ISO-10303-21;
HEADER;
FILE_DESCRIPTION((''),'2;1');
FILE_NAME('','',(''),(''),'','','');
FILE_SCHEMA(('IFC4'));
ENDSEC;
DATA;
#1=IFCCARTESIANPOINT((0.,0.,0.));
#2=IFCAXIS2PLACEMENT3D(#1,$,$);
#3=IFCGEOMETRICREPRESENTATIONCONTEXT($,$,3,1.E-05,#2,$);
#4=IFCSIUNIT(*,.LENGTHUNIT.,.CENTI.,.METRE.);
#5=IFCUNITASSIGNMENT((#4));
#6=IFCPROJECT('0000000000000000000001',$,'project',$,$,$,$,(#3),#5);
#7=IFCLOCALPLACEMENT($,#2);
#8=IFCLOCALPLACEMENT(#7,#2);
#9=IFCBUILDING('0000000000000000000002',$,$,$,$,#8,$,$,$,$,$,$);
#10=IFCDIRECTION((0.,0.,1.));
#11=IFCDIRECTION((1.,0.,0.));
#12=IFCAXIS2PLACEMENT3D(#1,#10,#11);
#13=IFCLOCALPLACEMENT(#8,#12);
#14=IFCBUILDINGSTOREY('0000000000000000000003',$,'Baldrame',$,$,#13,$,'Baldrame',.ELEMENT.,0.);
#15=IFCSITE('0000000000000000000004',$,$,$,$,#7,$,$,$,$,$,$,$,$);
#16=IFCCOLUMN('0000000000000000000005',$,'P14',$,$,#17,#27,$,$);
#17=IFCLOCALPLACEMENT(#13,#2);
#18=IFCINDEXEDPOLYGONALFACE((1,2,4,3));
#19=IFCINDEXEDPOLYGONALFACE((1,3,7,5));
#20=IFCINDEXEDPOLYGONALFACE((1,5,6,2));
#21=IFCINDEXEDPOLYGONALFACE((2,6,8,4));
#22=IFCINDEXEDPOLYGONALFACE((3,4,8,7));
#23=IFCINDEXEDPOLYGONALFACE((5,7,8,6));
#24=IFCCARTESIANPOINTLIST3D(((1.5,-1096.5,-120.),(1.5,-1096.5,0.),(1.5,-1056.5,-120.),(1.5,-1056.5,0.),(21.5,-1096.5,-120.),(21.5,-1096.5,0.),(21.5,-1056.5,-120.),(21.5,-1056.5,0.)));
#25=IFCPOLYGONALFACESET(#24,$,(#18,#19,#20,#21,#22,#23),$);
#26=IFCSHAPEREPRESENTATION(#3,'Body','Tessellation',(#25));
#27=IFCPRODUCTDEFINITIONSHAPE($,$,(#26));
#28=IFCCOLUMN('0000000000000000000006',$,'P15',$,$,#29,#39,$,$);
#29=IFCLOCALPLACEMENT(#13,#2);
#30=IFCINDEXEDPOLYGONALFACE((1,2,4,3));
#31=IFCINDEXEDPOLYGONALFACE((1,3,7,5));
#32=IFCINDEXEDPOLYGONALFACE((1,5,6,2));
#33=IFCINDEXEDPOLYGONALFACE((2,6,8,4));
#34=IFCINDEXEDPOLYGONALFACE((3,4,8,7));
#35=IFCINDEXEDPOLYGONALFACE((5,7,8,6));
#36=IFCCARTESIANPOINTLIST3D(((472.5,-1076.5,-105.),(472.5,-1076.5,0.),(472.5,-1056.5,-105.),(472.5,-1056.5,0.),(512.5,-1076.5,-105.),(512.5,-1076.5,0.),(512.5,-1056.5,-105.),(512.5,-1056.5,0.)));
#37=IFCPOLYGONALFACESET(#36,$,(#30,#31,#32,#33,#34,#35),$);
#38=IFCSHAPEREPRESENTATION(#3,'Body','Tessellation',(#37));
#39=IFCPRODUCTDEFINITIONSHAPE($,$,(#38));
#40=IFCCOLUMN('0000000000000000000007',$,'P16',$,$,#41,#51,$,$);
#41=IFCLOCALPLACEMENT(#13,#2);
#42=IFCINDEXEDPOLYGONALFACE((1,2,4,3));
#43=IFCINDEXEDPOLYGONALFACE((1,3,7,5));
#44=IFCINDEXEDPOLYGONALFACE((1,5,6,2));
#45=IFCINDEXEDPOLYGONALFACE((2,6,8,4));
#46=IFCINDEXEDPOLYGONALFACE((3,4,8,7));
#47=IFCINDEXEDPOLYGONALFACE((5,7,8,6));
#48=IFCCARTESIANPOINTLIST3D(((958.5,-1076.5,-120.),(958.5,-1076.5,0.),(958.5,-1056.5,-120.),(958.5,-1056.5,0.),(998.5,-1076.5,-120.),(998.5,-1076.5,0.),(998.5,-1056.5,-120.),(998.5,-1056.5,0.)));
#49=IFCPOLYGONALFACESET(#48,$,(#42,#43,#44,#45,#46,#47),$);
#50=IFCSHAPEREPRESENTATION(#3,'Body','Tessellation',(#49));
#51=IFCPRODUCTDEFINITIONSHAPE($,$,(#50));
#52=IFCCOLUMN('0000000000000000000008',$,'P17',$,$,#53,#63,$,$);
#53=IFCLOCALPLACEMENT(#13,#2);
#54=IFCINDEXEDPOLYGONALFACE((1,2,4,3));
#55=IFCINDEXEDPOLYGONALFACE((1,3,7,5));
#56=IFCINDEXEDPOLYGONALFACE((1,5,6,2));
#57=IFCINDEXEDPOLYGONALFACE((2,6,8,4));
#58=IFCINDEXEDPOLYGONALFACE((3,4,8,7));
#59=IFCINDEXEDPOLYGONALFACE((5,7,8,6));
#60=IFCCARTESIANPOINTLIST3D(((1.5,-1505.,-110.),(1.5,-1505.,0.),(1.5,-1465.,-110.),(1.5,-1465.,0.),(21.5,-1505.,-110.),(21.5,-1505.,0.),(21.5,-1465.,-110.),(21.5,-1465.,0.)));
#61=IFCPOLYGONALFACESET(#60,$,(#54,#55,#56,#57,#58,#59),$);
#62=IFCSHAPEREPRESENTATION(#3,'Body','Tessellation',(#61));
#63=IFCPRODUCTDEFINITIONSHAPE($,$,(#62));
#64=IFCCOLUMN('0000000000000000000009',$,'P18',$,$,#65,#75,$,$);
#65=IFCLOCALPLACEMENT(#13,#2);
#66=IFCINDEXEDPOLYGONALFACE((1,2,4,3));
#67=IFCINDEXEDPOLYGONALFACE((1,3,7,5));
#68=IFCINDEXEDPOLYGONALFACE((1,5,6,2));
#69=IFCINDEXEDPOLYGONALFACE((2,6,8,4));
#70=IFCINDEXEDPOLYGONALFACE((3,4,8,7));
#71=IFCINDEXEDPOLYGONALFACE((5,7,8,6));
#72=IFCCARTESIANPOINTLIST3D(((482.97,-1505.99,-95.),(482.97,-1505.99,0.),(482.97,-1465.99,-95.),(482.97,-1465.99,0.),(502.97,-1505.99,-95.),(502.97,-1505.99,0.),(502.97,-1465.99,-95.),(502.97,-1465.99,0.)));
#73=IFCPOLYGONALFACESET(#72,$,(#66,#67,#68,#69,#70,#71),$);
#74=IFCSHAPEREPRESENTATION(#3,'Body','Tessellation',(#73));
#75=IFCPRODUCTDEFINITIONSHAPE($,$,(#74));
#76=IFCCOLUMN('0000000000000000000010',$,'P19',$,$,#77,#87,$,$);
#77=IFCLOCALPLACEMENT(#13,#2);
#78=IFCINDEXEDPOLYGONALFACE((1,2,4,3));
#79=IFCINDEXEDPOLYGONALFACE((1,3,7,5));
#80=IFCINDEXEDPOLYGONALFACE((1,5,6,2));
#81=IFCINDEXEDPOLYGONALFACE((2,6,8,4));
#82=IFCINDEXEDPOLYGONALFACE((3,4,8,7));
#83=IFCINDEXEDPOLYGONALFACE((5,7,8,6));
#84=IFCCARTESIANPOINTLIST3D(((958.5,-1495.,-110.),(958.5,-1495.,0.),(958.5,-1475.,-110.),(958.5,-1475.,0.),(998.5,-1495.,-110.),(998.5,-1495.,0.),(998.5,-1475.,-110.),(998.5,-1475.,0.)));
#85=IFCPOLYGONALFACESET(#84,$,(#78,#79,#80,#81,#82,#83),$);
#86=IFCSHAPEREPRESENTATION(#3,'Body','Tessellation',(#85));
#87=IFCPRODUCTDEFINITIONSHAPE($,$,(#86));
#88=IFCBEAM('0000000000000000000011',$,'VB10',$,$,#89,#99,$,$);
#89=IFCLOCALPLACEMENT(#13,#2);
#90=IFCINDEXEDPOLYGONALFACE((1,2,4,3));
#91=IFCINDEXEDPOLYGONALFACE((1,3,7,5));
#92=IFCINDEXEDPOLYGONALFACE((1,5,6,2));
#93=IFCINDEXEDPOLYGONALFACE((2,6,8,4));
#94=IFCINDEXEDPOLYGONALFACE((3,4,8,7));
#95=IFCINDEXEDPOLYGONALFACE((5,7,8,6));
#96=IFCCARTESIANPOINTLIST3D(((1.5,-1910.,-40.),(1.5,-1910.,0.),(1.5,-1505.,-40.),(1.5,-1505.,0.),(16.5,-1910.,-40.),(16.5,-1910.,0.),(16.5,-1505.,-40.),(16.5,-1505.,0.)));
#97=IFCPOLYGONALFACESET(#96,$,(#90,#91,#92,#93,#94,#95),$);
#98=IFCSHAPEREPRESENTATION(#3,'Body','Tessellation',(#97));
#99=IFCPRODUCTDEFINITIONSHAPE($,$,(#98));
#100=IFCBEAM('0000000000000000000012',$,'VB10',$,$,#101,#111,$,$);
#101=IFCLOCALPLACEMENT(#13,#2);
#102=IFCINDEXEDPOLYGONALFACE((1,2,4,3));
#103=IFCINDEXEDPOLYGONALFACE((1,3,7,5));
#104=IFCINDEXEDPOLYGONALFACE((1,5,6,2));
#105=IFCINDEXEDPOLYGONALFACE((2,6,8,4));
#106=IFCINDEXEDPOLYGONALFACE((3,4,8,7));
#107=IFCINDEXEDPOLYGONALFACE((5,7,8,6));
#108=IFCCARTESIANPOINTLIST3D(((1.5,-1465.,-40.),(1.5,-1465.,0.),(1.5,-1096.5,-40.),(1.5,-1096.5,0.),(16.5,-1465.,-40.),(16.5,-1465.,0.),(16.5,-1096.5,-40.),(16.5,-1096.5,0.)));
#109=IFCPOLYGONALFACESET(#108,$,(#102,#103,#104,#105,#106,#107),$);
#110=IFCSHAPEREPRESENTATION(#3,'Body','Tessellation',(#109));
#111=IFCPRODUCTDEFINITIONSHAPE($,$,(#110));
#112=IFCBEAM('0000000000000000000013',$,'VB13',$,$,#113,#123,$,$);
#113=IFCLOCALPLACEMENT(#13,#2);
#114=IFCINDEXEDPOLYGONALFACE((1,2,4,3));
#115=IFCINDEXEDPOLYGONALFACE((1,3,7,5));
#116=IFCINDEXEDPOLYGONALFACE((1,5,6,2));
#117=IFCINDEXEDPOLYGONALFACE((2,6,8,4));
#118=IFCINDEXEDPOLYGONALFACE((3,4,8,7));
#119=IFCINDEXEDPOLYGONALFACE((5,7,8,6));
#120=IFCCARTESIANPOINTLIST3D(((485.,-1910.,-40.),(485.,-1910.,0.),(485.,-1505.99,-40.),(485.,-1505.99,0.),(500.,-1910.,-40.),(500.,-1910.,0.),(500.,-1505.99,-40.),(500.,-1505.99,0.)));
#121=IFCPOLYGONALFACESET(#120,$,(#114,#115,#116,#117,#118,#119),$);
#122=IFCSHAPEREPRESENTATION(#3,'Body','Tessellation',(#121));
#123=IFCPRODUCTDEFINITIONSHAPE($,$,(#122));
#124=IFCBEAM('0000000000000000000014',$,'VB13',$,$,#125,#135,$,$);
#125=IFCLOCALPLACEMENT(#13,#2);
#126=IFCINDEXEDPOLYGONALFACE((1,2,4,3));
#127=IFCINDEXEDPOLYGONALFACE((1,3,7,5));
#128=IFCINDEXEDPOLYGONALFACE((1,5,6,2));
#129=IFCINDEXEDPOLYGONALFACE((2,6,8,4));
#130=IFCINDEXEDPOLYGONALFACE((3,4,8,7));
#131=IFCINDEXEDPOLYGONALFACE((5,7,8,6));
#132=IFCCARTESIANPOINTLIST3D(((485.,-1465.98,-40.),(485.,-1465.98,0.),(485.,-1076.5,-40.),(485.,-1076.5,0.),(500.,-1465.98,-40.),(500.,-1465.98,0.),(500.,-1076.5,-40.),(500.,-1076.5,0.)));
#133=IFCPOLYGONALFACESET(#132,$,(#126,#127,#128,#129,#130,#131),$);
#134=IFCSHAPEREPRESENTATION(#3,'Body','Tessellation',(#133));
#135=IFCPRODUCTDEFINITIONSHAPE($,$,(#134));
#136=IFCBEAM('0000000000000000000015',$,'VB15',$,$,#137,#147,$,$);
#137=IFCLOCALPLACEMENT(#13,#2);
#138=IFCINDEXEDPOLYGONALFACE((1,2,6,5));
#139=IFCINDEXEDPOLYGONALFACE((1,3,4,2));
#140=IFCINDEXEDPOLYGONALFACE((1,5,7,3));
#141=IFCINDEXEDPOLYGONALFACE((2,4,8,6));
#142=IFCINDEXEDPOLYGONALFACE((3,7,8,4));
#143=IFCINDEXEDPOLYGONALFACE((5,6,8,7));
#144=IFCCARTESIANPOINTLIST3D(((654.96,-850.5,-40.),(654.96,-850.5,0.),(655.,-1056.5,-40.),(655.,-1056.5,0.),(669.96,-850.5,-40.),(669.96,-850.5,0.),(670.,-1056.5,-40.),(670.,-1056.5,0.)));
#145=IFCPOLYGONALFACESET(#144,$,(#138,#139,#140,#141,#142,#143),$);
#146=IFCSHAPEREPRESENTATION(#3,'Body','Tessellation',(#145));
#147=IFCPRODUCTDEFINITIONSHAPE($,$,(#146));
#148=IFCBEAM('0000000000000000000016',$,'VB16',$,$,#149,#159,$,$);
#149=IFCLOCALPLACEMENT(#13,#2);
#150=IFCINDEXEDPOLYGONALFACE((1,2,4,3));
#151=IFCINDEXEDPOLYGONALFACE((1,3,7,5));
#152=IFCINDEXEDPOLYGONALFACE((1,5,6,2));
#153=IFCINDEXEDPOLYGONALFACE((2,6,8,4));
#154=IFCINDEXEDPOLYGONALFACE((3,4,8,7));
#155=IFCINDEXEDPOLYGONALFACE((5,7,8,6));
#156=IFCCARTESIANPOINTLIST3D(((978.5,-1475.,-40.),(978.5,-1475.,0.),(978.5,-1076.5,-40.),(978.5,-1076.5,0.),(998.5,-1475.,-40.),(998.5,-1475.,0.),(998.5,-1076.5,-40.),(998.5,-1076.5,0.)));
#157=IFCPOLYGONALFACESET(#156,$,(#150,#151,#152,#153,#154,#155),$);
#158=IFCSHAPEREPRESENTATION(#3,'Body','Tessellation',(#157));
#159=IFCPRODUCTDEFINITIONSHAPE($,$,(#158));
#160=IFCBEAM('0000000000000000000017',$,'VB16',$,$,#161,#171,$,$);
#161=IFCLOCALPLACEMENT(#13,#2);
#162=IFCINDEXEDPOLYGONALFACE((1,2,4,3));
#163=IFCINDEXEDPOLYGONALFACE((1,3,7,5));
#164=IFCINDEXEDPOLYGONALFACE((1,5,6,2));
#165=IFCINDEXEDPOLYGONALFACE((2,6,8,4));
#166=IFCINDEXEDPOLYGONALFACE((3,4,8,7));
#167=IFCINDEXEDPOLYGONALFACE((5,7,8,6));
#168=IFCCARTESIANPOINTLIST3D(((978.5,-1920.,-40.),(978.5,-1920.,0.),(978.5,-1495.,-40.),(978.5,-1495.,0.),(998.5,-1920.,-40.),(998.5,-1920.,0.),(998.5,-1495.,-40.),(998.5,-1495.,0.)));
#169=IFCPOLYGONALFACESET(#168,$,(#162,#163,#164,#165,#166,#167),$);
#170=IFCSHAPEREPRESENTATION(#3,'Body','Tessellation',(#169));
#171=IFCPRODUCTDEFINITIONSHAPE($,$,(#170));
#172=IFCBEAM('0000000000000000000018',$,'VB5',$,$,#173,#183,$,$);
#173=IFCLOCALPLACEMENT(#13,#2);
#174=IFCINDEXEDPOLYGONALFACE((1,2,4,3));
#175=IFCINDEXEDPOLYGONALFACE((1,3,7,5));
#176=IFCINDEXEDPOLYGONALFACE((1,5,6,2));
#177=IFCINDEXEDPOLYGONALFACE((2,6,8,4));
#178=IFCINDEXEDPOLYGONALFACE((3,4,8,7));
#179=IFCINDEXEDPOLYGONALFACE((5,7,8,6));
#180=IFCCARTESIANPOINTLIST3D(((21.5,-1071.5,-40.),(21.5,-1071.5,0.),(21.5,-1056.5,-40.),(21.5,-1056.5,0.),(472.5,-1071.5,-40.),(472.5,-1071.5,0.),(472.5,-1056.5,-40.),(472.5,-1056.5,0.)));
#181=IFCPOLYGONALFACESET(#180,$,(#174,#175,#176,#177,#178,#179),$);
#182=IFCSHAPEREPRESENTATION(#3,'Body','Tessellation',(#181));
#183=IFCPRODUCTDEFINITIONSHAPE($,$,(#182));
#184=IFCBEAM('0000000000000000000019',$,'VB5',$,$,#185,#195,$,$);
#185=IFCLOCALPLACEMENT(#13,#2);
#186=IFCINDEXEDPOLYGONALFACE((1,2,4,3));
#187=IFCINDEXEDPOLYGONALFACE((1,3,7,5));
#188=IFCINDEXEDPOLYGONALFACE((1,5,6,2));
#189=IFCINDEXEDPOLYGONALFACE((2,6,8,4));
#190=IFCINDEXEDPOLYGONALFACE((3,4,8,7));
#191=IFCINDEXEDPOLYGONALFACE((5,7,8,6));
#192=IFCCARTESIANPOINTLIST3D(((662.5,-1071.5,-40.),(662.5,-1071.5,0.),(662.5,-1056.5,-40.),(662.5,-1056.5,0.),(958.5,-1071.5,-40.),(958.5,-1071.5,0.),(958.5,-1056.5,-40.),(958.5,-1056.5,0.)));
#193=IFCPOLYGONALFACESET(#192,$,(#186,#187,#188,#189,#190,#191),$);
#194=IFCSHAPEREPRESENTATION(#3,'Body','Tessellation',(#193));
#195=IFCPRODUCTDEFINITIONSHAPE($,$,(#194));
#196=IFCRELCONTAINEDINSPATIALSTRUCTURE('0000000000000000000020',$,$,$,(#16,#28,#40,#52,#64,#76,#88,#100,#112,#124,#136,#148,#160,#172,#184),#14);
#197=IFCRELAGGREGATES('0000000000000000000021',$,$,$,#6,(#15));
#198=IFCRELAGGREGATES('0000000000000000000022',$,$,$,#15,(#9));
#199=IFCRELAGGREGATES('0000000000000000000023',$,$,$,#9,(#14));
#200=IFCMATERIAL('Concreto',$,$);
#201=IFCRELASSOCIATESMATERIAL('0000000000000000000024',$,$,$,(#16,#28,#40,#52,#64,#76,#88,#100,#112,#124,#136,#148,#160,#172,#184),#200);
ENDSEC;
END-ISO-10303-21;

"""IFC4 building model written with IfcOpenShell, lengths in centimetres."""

from ifc_helpers import new_model, si_unit, frame, origin, origin_with_axes, place, context, project, spatial, polyline, outline, extrude, material, element, save


model = new_model("IFC4")

# Units and contexts
context_of_model = context(None, 3, precision=1e-05, world=origin())
ifc_project = project(units=[si_unit("LENGTHUNIT", "METRE", prefix="CENTI")], contexts=[context_of_model])

# Site, building, storey
site_placement = place(None, origin())
site = spatial("IfcSite", under=ifc_project, at=site_placement)
building_placement = place(site_placement, origin())
building = spatial("IfcBuilding", under=site, at=building_placement)
storey_placement = place(building_placement, origin_with_axes())
storey = spatial("IfcBuildingStorey", under=building, at=storey_placement, Name="Baldrame", LongName="Baldrame", CompositionType="ELEMENT", Elevation=0.0)

# Columns
ifc_material = material(Name="Concreto")
column_1_placement = place(storey_placement, frame((11.5, -1076.5, 0.0), z_axis=(0.0, 0.0, 1.0), x_axis=(1.0, 0.0, 0.0)))
element("IfcColumn", 1, at=column_1_placement, inside=storey, material=ifc_material, Name="P14", context=context_of_model, shape_type="SolidModel", body=[
    extrude(outline(polyline([(10.0, 20.0), (-10.0, 20.0), (-10.0, -20.0), (10.0, -20.0), (10.0, 20.0)])), frame((0.0, 0.0, -120.0), z_axis=(0.0, 0.0, 1.0), x_axis=(1.0, 0.0, 0.0)), (0.0, 0.0, 1.0), 120.0),
])
column_2_placement = place(storey_placement, frame((492.5, -1066.5, 0.0), z_axis=(0.0, 0.0, 1.0), x_axis=(1.0, 0.0, 0.0)))
element("IfcColumn", 2, at=column_2_placement, inside=storey, material=ifc_material, Name="P15", context=context_of_model, shape_type="SolidModel", body=[
    extrude(outline(polyline([(-20.0, 10.0), (-20.0, -10.0), (20.0, -10.0), (20.0, 10.0), (-20.0, 10.0)])), frame((0.0, 0.0, -105.0), z_axis=(0.0, 0.0, 1.0), x_axis=(1.0, 0.0, 0.0)), (0.0, 0.0, 1.0), 105.0),
])
column_3_placement = place(storey_placement, frame((978.5, -1066.5, 0.0), z_axis=(0.0, 0.0, 1.0), x_axis=(1.0, 0.0, 0.0)))
element("IfcColumn", 3, at=column_3_placement, inside=storey, material=ifc_material, Name="P16", context=context_of_model, shape_type="SolidModel", body=[
    extrude(outline(polyline([(-20.0, 10.0), (-20.0, -10.0), (20.0, -10.0), (20.0, 10.0), (-20.0, 10.0)])), frame((0.0, 0.0, -120.0), z_axis=(0.0, 0.0, 1.0), x_axis=(1.0, 0.0, 0.0)), (0.0, 0.0, 1.0), 120.0),
])
column_4_placement = place(storey_placement, frame((11.5, -1485.0, 0.0), z_axis=(0.0, 0.0, 1.0), x_axis=(1.0, 0.0, 0.0)))
element("IfcColumn", 4, at=column_4_placement, inside=storey, material=ifc_material, Name="P17", context=context_of_model, shape_type="SolidModel", body=[
    extrude(outline(polyline([(-10.0, -20.0), (10.0, -20.0), (10.0, 20.0), (-10.0, 20.0), (-10.0, -20.0)])), frame((0.0, 0.0, -110.0), z_axis=(0.0, 0.0, 1.0), x_axis=(1.0, 0.0, 0.0)), (0.0, 0.0, 1.0), 110.0),
])
column_5_placement = place(storey_placement, frame((492.97, -1485.99, 0.0), z_axis=(0.0, 0.0, 1.0), x_axis=(1.0, 0.0, 0.0)))
element("IfcColumn", 5, at=column_5_placement, inside=storey, material=ifc_material, Name="P18", context=context_of_model, shape_type="SolidModel", body=[
    extrude(outline(polyline([(-10.0, -20.0), (10.0, -20.0), (10.0, 20.0), (-10.0, 20.0), (-10.0, -20.0)])), frame((0.0, 0.0, -95.0), z_axis=(0.0, 0.0, 1.0), x_axis=(1.0, 0.0, 0.0)), (0.0, 0.0, 1.0), 95.0),
])
column_6_placement = place(storey_placement, frame((978.5, -1485.0, 0.0), z_axis=(0.0, 0.0, 1.0), x_axis=(1.0, 0.0, 0.0)))
element("IfcColumn", 6, at=column_6_placement, inside=storey, material=ifc_material, Name="P19", context=context_of_model, shape_type="SolidModel", body=[
    extrude(outline(polyline([(-20.0, 10.0), (-20.0, -10.0), (20.0, -10.0), (20.0, 10.0), (-20.0, 10.0)])), frame((0.0, 0.0, -110.0), z_axis=(0.0, 0.0, 1.0), x_axis=(1.0, 0.0, 0.0)), (0.0, 0.0, 1.0), 110.0),
])

# Beams
beam_1_placement = place(storey_placement, frame((9.0, -1707.5, 0.0), z_axis=(0.0, 0.0, 1.0), x_axis=(1.0, 0.0, 0.0)))
element("IfcBeam", 7, at=beam_1_placement, inside=storey, material=ifc_material, Name="VB10", context=context_of_model, shape_type="SolidModel", body=[
    extrude(outline(polyline([(-7.5, -20.0), (7.5, -20.0), (7.5, 20.0), (-7.5, 20.0), (-7.5, -20.0)])), frame((0.0, -202.5, -20.0), z_axis=(0.0, 1.0, 0.0), x_axis=(1.0, 0.0, 0.0)), (0.0, 0.0, 1.0), 405.0),
])
beam_2_placement = place(storey_placement, frame((9.0, -1280.75, 0.0), z_axis=(0.0, 0.0, 1.0), x_axis=(1.0, 0.0, 0.0)))
element("IfcBeam", 8, at=beam_2_placement, inside=storey, material=ifc_material, Name="VB10", context=context_of_model, shape_type="SolidModel", body=[
    extrude(outline(polyline([(-7.5, -20.0), (7.5, -20.0), (7.5, 20.0), (-7.5, 20.0), (-7.5, -20.0)])), frame((0.0, -184.25, -20.0), z_axis=(0.0, 1.0, 0.0), x_axis=(1.0, 0.0, 0.0)), (0.0, 0.0, 1.0), 368.5),
])
beam_3_placement = place(storey_placement, frame((492.5, -1707.99, 0.0), z_axis=(0.0, 0.0, 1.0), x_axis=(1.0, 0.0, 0.0)))
element("IfcBeam", 9, at=beam_3_placement, inside=storey, material=ifc_material, Name="VB13", context=context_of_model, shape_type="SolidModel", body=[
    extrude(outline(polyline([(-7.5, -20.0), (7.5, -20.0), (7.5, 20.0), (-7.5, 20.0), (-7.5, -20.0)])), frame((0.0, -202.0, -20.0), z_axis=(0.0, 1.0, 0.0), x_axis=(1.0, 0.0, 0.0)), (0.0, 0.0, 1.0), 404.01),
])
beam_4_placement = place(storey_placement, frame((492.5, -1271.24, 0.0), z_axis=(0.0, 0.0, 1.0), x_axis=(1.0, 0.0, 0.0)))
element("IfcBeam", 10, at=beam_4_placement, inside=storey, material=ifc_material, Name="VB13", context=context_of_model, shape_type="SolidModel", body=[
    extrude(outline(polyline([(-7.5, -20.0), (7.5, -20.0), (7.5, 20.0), (-7.5, 20.0), (-7.5, -20.0)])), frame((0.0, -194.75, -20.0), z_axis=(0.0, 1.0, 0.0), x_axis=(1.0, 0.0, 0.0)), (0.0, 0.0, 1.0), 389.49),
])
beam_5_placement = place(storey_placement, frame((662.48, -953.5, 0.0), z_axis=(0.0, 0.0, 1.0), x_axis=(1.0, 0.0, 0.0)))
element("IfcBeam", 11, at=beam_5_placement, inside=storey, material=ifc_material, Name="VB15", context=context_of_model, shape_type="SolidModel", body=[
    extrude(outline(polyline([(-7.5, -20.0), (7.5, -20.0), (7.5, 20.0), (-7.5, 20.0), (-7.5, -20.0)])), frame((0.02, -103.0, -20.0), z_axis=(-0.000187, 1.0, 0.0), x_axis=(1.0, 0.000187, 0.0)), (0.0, 0.0, 1.0), 206.0),
])
beam_6_placement = place(storey_placement, frame((988.5, -1275.75, 0.0), z_axis=(0.0, 0.0, 1.0), x_axis=(1.0, 0.0, 0.0)))
element("IfcBeam", 12, at=beam_6_placement, inside=storey, material=ifc_material, Name="VB16", context=context_of_model, shape_type="SolidModel", body=[
    extrude(outline(polyline([(-10.0, -20.0), (10.0, -20.0), (10.0, 20.0), (-10.0, 20.0), (-10.0, -20.0)])), frame((0.0, -199.25, -20.0), z_axis=(0.0, 1.0, 0.0), x_axis=(1.0, 0.0, 0.0)), (0.0, 0.0, 1.0), 398.5),
])
beam_7_placement = place(storey_placement, frame((988.5, -1707.5, 0.0), z_axis=(0.0, 0.0, 1.0), x_axis=(1.0, 0.0, 0.0)))
element("IfcBeam", 13, at=beam_7_placement, inside=storey, material=ifc_material, Name="VB16", context=context_of_model, shape_type="SolidModel", body=[
    extrude(outline(polyline([(-10.0, -20.0), (10.0, -20.0), (10.0, 20.0), (-10.0, 20.0), (-10.0, -20.0)])), frame((0.0, -212.5, -20.0), z_axis=(0.0, 1.0, 0.0), x_axis=(1.0, 0.0, 0.0)), (0.0, 0.0, 1.0), 425.0),
])
beam_8_placement = place(storey_placement, frame((247.0, -1064.0, 0.0), z_axis=(0.0, 0.0, 1.0), x_axis=(1.0, 0.0, 0.0)))
element("IfcBeam", 14, at=beam_8_placement, inside=storey, material=ifc_material, Name="VB5", context=context_of_model, shape_type="SolidModel", body=[
    extrude(outline(polyline([(-7.5, -20.0), (7.5, -20.0), (7.5, 20.0), (-7.5, 20.0), (-7.5, -20.0)])), frame((-225.5, 0.0, -20.0), z_axis=(1.0, 0.0, 0.0), x_axis=(0.0, -1.0, 0.0)), (0.0, 0.0, 1.0), 451.0),
])
beam_9_placement = place(storey_placement, frame((810.5, -1064.0, 0.0), z_axis=(0.0, 0.0, 1.0), x_axis=(1.0, 0.0, 0.0)))
element("IfcBeam", 15, at=beam_9_placement, inside=storey, material=ifc_material, Name="VB5", context=context_of_model, shape_type="SolidModel", body=[
    extrude(outline(polyline([(-7.5, -20.0), (7.5, -20.0), (7.5, 20.0), (-7.5, 20.0), (-7.5, -20.0)])), frame((-148.0, 0.0, -20.0), z_axis=(1.0, 0.0, 0.0), x_axis=(0.0, -1.0, 0.0)), (0.0, 0.0, 1.0), 296.0),
])

save(model, "model.ifc")
